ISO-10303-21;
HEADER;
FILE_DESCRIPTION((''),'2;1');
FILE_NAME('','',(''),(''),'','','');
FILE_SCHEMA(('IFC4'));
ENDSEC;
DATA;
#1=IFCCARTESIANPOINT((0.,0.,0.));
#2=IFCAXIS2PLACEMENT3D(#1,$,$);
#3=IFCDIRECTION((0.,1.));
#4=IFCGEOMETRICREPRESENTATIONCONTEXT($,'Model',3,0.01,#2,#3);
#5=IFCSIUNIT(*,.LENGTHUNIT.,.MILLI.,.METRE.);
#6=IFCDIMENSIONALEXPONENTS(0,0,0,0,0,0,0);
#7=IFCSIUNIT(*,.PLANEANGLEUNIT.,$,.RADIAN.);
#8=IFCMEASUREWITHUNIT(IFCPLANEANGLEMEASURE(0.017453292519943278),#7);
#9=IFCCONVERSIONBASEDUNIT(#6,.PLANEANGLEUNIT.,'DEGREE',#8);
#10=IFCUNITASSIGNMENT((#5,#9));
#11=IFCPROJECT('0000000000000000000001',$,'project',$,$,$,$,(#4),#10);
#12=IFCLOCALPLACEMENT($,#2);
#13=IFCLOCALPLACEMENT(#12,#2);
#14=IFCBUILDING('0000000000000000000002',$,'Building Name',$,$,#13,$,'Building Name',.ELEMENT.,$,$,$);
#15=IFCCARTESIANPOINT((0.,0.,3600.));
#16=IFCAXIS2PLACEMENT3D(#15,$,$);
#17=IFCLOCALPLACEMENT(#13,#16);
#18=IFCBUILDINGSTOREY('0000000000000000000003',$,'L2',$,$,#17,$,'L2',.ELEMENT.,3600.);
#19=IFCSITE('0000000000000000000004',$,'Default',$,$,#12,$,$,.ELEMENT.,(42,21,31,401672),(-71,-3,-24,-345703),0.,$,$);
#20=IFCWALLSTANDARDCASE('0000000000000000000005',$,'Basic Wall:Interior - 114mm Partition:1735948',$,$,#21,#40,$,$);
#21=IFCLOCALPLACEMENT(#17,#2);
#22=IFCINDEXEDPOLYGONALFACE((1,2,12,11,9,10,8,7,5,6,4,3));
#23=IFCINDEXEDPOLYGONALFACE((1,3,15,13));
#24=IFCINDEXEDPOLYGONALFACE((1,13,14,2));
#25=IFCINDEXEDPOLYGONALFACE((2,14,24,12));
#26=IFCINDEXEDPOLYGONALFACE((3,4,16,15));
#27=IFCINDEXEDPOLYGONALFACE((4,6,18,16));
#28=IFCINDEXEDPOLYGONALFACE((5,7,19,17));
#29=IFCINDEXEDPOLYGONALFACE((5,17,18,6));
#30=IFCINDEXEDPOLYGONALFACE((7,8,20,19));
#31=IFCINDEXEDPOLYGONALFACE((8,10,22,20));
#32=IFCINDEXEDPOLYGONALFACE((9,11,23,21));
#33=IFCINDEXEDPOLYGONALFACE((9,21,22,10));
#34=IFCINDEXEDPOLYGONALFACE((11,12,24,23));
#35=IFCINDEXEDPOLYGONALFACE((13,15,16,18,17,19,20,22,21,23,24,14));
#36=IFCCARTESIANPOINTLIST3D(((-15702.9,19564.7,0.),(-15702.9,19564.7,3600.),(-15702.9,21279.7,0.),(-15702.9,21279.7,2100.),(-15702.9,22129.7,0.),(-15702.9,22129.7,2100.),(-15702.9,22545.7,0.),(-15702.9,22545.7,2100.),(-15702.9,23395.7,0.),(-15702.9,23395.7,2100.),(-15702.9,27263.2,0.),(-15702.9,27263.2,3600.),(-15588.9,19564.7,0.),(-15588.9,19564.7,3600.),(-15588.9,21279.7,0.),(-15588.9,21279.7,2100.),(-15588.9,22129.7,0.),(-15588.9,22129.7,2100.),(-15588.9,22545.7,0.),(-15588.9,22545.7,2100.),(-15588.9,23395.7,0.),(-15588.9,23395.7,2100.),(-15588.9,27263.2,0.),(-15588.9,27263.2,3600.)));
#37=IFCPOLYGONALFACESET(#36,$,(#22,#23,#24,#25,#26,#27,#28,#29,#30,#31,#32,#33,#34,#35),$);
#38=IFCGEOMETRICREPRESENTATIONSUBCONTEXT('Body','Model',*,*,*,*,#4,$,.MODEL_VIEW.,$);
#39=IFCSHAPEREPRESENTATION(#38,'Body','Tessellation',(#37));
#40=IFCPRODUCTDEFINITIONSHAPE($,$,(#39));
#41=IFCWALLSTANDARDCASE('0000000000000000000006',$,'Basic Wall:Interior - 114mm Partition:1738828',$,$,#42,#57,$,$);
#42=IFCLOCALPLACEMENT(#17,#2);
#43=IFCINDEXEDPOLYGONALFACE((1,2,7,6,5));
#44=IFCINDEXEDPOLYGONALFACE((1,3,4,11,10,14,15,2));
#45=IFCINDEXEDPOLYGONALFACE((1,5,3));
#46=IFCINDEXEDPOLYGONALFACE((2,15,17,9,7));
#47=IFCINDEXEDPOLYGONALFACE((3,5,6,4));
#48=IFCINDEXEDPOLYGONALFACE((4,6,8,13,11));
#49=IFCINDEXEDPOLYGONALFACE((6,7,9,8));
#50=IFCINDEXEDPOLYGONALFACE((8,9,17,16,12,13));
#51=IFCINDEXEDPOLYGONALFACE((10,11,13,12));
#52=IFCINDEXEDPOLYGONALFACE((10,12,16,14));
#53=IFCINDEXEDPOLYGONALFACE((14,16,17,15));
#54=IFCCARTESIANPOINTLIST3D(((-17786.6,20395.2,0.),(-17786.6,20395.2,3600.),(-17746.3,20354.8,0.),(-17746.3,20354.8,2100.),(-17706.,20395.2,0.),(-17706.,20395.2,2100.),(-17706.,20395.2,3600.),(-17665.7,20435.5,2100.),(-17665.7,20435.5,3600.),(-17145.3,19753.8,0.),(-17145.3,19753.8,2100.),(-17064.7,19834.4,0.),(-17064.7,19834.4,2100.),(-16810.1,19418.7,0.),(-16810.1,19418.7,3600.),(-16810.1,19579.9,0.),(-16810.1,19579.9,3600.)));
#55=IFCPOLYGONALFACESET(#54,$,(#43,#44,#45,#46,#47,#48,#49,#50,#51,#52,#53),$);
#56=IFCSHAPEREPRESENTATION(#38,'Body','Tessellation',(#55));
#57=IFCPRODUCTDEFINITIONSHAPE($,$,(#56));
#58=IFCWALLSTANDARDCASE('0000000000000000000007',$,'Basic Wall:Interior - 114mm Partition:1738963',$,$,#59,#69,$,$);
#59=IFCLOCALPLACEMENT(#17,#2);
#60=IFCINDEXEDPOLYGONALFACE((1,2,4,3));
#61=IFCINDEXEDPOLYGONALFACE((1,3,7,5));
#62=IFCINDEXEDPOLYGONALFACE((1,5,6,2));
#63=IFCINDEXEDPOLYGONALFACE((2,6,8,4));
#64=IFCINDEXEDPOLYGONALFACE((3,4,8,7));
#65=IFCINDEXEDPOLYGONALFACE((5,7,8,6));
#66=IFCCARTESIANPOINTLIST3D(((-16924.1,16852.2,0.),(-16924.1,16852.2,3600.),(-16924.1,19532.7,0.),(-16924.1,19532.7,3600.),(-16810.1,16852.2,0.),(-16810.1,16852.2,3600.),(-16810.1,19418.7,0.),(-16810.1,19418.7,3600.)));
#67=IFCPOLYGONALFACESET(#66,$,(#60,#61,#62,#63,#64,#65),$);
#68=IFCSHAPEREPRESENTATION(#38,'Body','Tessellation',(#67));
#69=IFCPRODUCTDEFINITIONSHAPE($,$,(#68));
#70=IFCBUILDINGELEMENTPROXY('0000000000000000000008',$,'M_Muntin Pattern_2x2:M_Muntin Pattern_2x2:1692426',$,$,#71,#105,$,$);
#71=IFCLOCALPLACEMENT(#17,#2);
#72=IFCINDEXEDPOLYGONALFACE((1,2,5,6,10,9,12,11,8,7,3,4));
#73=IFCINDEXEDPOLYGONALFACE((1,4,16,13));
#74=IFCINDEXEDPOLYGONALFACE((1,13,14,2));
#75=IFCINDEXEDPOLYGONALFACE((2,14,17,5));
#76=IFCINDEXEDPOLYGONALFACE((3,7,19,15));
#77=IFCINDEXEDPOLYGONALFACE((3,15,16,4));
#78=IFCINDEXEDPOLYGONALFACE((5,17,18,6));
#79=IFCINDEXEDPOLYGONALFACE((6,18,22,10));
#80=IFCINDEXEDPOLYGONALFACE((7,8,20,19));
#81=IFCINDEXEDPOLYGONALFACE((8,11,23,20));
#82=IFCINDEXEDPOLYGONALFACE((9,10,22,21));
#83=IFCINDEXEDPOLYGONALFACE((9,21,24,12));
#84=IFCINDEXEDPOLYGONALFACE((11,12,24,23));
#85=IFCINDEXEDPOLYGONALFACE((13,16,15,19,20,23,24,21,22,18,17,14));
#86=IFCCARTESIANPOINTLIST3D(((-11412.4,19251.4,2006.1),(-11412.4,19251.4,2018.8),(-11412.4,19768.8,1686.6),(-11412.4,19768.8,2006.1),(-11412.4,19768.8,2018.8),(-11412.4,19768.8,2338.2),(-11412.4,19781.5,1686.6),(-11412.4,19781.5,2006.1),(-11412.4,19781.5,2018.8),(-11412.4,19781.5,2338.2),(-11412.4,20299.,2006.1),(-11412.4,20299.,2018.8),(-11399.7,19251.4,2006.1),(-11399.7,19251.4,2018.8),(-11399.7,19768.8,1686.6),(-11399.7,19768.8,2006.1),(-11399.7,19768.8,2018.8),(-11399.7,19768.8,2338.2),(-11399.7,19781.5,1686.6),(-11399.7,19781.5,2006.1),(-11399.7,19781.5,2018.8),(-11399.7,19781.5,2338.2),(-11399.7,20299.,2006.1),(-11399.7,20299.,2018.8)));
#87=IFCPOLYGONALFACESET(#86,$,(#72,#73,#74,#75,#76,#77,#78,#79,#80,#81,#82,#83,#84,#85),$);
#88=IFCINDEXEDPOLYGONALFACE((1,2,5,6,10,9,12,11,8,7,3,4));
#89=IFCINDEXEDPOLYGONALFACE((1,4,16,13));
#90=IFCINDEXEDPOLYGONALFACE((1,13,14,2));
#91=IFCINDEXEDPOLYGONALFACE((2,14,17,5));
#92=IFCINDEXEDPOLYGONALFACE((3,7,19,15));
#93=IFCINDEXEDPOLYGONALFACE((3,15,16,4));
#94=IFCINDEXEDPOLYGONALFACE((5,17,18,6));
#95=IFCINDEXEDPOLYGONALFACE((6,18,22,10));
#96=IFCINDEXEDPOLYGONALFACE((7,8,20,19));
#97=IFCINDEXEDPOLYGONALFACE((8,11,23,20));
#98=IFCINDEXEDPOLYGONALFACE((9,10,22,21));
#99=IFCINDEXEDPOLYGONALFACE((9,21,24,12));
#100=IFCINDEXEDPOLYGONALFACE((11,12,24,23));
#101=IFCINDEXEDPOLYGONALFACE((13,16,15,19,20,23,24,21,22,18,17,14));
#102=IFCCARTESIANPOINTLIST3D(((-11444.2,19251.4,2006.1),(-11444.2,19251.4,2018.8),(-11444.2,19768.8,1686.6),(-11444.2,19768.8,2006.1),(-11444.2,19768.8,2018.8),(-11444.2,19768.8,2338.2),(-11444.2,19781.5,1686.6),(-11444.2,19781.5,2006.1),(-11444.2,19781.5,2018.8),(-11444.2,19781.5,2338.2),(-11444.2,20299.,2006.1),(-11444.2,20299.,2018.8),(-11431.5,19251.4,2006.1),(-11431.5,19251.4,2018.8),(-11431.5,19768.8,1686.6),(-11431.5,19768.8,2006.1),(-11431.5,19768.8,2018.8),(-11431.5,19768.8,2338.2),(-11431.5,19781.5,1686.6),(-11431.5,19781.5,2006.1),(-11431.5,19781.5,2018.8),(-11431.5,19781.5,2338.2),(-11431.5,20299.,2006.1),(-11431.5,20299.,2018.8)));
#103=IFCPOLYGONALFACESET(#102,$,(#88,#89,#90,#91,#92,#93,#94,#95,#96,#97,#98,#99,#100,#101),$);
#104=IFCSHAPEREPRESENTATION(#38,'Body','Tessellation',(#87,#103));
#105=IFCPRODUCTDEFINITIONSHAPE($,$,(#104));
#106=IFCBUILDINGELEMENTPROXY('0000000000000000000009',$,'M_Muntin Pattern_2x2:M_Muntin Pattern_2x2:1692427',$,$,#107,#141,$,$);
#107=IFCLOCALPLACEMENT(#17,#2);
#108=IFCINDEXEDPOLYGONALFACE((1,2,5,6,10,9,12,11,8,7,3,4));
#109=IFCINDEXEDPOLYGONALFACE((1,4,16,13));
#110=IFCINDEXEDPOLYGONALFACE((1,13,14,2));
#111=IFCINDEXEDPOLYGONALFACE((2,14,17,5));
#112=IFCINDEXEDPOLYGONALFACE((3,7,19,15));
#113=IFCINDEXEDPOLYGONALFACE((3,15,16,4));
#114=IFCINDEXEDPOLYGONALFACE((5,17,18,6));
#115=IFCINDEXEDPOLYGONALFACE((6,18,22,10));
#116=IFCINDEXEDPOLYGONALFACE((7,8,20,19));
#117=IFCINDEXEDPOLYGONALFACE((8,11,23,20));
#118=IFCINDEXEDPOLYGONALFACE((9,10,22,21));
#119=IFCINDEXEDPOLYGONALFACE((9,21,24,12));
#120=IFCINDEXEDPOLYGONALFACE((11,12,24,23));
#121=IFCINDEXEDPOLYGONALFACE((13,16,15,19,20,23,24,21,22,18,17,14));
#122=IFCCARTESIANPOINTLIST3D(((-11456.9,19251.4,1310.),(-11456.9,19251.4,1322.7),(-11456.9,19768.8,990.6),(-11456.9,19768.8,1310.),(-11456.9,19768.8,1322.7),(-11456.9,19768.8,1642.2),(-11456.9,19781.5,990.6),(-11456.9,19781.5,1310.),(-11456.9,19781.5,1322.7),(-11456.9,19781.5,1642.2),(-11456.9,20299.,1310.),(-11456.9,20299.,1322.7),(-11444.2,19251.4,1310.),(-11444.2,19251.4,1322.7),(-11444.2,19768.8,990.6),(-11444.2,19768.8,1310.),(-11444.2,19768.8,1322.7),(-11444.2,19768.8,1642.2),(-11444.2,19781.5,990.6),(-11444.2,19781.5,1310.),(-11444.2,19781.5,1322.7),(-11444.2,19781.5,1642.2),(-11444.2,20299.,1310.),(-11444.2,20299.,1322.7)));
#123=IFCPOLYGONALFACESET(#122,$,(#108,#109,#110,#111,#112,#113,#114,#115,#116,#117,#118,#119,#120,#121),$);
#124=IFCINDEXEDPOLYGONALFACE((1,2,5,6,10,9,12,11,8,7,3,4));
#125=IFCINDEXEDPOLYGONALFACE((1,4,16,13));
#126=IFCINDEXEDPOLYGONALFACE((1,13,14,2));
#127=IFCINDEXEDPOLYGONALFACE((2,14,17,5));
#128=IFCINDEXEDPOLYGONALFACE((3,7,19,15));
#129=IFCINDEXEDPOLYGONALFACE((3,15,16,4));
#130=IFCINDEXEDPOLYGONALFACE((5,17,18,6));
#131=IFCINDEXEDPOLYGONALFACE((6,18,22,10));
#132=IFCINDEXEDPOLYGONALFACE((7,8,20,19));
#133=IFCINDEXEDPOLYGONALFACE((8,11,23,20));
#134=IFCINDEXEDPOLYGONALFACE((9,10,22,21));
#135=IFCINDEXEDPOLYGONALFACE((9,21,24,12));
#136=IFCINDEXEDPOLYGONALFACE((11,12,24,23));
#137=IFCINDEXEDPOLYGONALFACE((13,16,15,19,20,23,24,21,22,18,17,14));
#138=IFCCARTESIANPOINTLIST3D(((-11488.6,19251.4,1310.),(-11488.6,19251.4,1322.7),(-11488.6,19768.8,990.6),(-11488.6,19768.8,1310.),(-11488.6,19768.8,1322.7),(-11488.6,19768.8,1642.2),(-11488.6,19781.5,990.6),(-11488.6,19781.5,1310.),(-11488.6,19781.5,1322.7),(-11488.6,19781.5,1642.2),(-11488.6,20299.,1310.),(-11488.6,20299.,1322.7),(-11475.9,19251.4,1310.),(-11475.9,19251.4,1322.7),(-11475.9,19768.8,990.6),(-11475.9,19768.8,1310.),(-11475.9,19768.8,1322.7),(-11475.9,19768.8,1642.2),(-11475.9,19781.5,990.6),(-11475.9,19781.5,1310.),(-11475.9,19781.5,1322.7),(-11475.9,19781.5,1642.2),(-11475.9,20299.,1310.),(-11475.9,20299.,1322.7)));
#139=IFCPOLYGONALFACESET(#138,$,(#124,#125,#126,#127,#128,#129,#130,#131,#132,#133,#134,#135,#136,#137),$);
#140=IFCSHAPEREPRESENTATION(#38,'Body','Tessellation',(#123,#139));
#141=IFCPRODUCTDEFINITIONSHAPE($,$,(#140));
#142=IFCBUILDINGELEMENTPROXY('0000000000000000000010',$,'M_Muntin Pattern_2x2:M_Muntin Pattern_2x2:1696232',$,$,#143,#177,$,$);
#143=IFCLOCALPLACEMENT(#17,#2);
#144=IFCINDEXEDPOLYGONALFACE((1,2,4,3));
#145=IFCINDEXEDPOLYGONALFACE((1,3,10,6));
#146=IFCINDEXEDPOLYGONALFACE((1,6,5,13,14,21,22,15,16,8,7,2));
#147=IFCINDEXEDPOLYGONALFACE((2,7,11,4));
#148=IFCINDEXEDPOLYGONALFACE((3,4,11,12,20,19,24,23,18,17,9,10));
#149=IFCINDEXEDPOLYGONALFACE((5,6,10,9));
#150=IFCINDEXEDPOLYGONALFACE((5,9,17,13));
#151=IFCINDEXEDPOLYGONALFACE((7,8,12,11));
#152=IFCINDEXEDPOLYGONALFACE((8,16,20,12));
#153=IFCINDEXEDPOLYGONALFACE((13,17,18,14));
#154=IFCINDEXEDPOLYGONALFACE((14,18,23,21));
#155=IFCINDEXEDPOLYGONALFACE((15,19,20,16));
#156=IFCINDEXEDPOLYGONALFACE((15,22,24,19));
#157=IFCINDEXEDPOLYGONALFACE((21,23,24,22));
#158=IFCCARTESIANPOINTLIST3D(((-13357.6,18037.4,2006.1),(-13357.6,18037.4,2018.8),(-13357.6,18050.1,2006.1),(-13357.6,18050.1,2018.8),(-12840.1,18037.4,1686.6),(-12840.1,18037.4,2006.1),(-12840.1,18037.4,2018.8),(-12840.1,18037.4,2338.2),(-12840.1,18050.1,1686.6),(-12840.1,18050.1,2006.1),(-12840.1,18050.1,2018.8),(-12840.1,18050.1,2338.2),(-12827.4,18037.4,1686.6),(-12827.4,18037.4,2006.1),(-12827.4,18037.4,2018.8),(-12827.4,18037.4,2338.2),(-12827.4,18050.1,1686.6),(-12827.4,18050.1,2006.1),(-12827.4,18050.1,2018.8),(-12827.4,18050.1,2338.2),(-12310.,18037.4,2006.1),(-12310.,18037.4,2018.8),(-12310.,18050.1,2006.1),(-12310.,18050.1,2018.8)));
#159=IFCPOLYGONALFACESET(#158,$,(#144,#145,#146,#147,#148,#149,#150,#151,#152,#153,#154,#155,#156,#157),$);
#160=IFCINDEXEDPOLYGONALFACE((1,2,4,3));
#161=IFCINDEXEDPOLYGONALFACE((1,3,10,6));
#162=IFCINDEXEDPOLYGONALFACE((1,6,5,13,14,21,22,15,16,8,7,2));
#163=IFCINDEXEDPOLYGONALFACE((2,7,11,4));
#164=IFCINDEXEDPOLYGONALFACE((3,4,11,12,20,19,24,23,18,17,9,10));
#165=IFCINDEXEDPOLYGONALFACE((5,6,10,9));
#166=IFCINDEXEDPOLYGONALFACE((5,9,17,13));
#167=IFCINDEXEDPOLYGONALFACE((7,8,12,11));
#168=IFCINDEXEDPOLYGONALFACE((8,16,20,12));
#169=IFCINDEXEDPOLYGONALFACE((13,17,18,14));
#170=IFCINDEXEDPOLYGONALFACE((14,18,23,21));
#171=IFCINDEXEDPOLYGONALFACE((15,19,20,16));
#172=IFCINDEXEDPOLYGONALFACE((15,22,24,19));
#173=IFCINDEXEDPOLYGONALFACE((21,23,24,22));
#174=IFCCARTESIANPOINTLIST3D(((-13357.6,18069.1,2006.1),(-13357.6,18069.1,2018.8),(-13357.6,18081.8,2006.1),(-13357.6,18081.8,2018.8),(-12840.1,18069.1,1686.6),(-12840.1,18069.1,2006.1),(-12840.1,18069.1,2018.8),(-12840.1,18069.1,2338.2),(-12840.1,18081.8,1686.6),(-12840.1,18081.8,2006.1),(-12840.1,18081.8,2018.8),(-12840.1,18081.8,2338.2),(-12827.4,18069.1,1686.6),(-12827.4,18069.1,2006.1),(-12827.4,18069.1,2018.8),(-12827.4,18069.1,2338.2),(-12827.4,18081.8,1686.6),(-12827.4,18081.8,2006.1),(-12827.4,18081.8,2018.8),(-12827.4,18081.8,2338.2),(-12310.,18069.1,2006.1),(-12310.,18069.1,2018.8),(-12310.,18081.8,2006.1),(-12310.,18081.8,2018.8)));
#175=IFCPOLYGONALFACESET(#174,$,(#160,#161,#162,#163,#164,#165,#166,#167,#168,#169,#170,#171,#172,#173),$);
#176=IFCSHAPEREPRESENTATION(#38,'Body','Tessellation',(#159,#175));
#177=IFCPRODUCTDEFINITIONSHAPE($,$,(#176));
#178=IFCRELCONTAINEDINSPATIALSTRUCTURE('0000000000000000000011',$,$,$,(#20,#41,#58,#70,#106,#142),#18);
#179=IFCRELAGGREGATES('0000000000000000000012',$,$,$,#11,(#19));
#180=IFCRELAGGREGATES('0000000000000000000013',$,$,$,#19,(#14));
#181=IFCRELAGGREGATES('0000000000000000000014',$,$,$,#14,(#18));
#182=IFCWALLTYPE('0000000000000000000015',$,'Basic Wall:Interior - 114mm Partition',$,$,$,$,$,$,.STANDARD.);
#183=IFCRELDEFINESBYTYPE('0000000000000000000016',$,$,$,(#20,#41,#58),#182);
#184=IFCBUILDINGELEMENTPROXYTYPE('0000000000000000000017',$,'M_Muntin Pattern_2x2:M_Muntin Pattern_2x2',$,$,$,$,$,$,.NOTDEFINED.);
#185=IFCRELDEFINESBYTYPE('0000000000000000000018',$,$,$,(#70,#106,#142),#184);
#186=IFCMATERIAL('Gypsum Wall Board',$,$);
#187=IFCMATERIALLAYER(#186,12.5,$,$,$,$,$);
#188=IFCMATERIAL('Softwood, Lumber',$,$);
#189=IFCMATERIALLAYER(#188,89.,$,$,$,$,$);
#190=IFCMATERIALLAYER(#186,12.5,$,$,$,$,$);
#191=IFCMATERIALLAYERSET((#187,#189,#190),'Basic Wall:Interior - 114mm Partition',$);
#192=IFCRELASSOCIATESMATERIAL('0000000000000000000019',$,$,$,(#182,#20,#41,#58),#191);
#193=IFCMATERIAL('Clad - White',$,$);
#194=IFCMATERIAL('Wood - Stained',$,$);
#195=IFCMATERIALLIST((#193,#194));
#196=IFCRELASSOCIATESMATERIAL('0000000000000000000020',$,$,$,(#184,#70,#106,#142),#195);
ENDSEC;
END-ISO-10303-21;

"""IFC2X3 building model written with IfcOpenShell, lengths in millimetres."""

from ifc_helpers import new_model, entity, si_unit, converted_unit, direction, frame, frame_2d, origin, place, context, subcontext, project, spatial, polyline, rectangle, outline, extrude, source, transform, mapped, material, material_list, layer, layer_set, layer_usage, type_object, type_shapes, element, save


model = new_model("IFC2X3")

# Units and contexts
model_context = context("Model", 3, precision=0.01, world=origin(), true_north=direction((0.0, 1.0)))
body_context = subcontext(model_context, "Body", "Model", "MODEL_VIEW")
ifc_project = project(units=[si_unit("LENGTHUNIT", "METRE", prefix="MILLI"), converted_unit("PLANEANGLEUNIT", "DEGREE", entity("IfcPlaneAngleMeasure", 0.017453292519943278), si_unit("PLANEANGLEUNIT", "RADIAN"), dimensions=[0, 0, 0, 0, 0, 0, 0])], contexts=[model_context])

# Site, building, storey
site_placement = place(None, origin())
site = spatial("IfcSite", under=ifc_project, at=site_placement, Name="Default", CompositionType="ELEMENT", RefLatitude=(42, 21, 31, 401672), RefLongitude=(-71, -3, -24, -345703), RefElevation=0.0)
building_placement = place(site_placement, origin())
building = spatial("IfcBuilding", under=site, at=building_placement, Name="Building Name", LongName="Building Name", CompositionType="ELEMENT")
storey_placement = place(building_placement, frame((0.0, 0.0, 3600.0)))
storey = spatial("IfcBuildingStorey", under=building, at=storey_placement, Name="L2", LongName="L2", CompositionType="ELEMENT", Elevation=3600.0)

# Shared definitions
ifc_material_1 = material(Name="Gypsum Wall Board")
ifc_material_2 = material(Name="Wood - Stained")

# Shared definitions
ifc_layer_1 = layer(ifc_material_1, 12.5)
ifc_material_3 = material(Name="Softwood, Lumber")
ifc_layer_2 = layer(ifc_material_3, 89.0)
ifc_layer_3 = layer(ifc_material_1, 12.5)
ifc_layer_set_1 = layer_set([ifc_layer_1, ifc_layer_2, ifc_layer_3], Name="Basic Wall:Interior - 114mm Partition")
wall_type_1 = type_object("IfcWallType", Name="Basic Wall:Interior - 114mm Partition", PredefinedType="STANDARD", material=ifc_layer_set_1)

# Wall, openings
ifc_layer_usage_1 = layer_usage(ifc_layer_set_1, "AXIS2", "NEGATIVE", 57.0)
wall_1_placement = place(storey_placement, frame((-15645.9, 19564.7, 0.0), z_axis=(0.0, 0.0, 1.0), x_axis=(0.0, 1.0, 0.0)))
wall_1 = element("IfcWallStandardCase", 1, at=wall_1_placement, inside=storey, type_object=wall_type_1, material=ifc_layer_usage_1, Name="Basic Wall:Interior - 114mm Partition:1735948", context=body_context, shape_type="SweptSolid", body=[
    extrude(rectangle(XDim=7698.5, YDim=114.0, at=frame_2d((3849.2, 0.0), x_axis=(-1.0, 0.0))), origin(), (0.0, 0.0, 1.0), 3600.0),
])
opening_1_placement = place(wall_1_placement, frame((3831.0, 57.0, 0.0)))
element("IfcOpeningElement", 2, at=opening_1_placement, cuts=wall_1, ObjectType="Opening", context=body_context, shape_type="SweptSolid", body=[
    extrude(rectangle(XDim=2100.0, YDim=850.0, at=frame_2d((1050.0, 425.0), x_axis=(1.0, 0.0))), frame((0.0, 0.0, 0.0), z_axis=(0.0, -1.0, 0.0), x_axis=(0.0, 0.0, 1.0)), (0.0, 0.0, 1.0), 114.0),
])
opening_2_placement = place(wall_1_placement, frame((2565.0, 57.0, 0.0)))
element("IfcOpeningElement", 3, at=opening_2_placement, cuts=wall_1, ObjectType="Opening", context=body_context, shape_type="SweptSolid", body=[
    extrude(rectangle(XDim=2100.0, YDim=850.0, at=frame_2d((1050.0, 425.0), x_axis=(1.0, 0.0))), frame((0.0, 0.0, 0.0), z_axis=(0.0, -1.0, 0.0), x_axis=(0.0, 0.0, 1.0)), (0.0, 0.0, 1.0), 114.0),
])

# Wall, opening
ifc_layer_usage_2 = layer_usage(ifc_layer_set_1, "AXIS2", "NEGATIVE", 57.0)
wall_2_placement = place(storey_placement, frame((-17746.3, 20435.5, 0.0), z_axis=(0.0, 0.0, 1.0), x_axis=(0.707107, -0.707107, 0.0)))
wall_2 = element("IfcWallStandardCase", 4, at=wall_2_placement, inside=storey, type_object=wall_type_1, material=ifc_layer_usage_2, Name="Basic Wall:Interior - 114mm Partition:1738828", context=body_context, shape_type="SweptSolid", body=[
    extrude(outline(polyline([(0.0, -57.0), (1219.8, -57.0), (1381.0, -57.0), (1267.0, 57.0), (57.0, 57.0), (57.0, 0.0), (0.0, -57.0)])), origin(), (0.0, 0.0, 1.0), 3600.0),
])
opening_3_placement = place(wall_2_placement, frame((907.0, 57.0, 0.0)))
element("IfcOpeningElement", 5, at=opening_3_placement, cuts=wall_2, ObjectType="Opening", context=body_context, shape_type="SweptSolid", body=[
    extrude(rectangle(XDim=2100.0, YDim=850.0, at=frame_2d((1050.0, 425.0), x_axis=(1.0, 0.0))), frame((0.0, 0.0, 0.0), z_axis=(0.0, -1.0, 0.0), x_axis=(0.0, 0.0, 1.0)), (0.0, 0.0, 1.0), 114.0),
])

# Wall
ifc_layer_usage_3 = layer_usage(ifc_layer_set_1, "AXIS2", "NEGATIVE", 57.0)
wall_3_placement = place(storey_placement, frame((-16867.1, 19532.7, 0.0), z_axis=(0.0, 0.0, 1.0), x_axis=(0.0, -1.0, 0.0)))
element("IfcWallStandardCase", 6, at=wall_3_placement, inside=storey, type_object=wall_type_1, material=ifc_layer_usage_3, Name="Basic Wall:Interior - 114mm Partition:1738963", context=body_context, shape_type="SweptSolid", body=[
    extrude(outline(polyline([(2680.5, -57.0), (2680.5, 57.0), (114.0, 57.0), (0.0, -57.0), (2680.5, -57.0)])), origin(), (0.0, 0.0, 1.0), 3600.0),
])

# Building element proxies
ifc_material_4 = material(Name="Clad - White")
ifc_material_list_1 = material_list([ifc_material_4, ifc_material_2])
building_element_proxy_type_1 = type_object("IfcBuildingElementProxyType", Name="M_Muntin Pattern_2x2:M_Muntin Pattern_2x2", PredefinedType="NOTDEFINED", material=ifc_material_list_1)
shared_shape_1 = source(origin(), body_context, "Body", "SweptSolid", [
    extrude(outline(polyline([(6.4, -6.4), (325.8, -6.4), (325.8, 6.3), (6.4, 6.3), (6.4, 523.8), (-6.3, 523.8), (-6.3, 6.3), (-325.8, 6.3), (-325.8, -6.4), (-6.3, -6.4), (-6.3, -523.8), (6.4, -523.8), (6.4, -6.4)])), frame((0.0, 9.5, 325.8), z_axis=(0.0, 1.0, 0.0), x_axis=(0.0, 0.0, 1.0)), (0.0, 0.0, 1.0), 12.7),
    extrude(outline(polyline([(6.4, -6.4), (325.8, -6.4), (325.8, 6.3), (6.4, 6.3), (6.4, 523.8), (-6.3, 523.8), (-6.3, 6.3), (-325.8, 6.3), (-325.8, -6.4), (-6.3, -6.4), (-6.3, -523.8), (6.4, -523.8), (6.4, -6.4)])), frame((0.0, -22.2, 325.8), z_axis=(0.0, 1.0, 0.0), x_axis=(0.0, 0.0, 1.0)), (0.0, 0.0, 1.0), 12.7),
])
type_shapes(building_element_proxy_type_1, [shared_shape_1])
for number, where, z_axis, x_axis, name in (
    (7, (-11422.0, 19775.2, 1686.6), (0.0, 0.0, 1.0), (0.0, -1.0, 0.0), "M_Muntin Pattern_2x2:M_Muntin Pattern_2x2:1692426"),
    (8, (-11466.4, 19775.2, 990.6), (0.0, 0.0, 1.0), (0.0, -1.0, 0.0), "M_Muntin Pattern_2x2:M_Muntin Pattern_2x2:1692427"),
    (9, (-12833.8, 18059.6, 1686.6), (0.0, 0.0, 1.0), (-1.0, 0.0, 0.0), "M_Muntin Pattern_2x2:M_Muntin Pattern_2x2:1696232"),
):
    element("IfcBuildingElementProxy", number, at=place(storey_placement, frame(where, z_axis=z_axis, x_axis=x_axis)), inside=storey, type_object=building_element_proxy_type_1, material=ifc_material_list_1, Name=name, context=body_context, shape_type="MappedRepresentation", body=[
        mapped(shared_shape_1, transform((0.0, 0.0, 0.0), scale=1.0)),
    ])

save(model, "model.ifc")
